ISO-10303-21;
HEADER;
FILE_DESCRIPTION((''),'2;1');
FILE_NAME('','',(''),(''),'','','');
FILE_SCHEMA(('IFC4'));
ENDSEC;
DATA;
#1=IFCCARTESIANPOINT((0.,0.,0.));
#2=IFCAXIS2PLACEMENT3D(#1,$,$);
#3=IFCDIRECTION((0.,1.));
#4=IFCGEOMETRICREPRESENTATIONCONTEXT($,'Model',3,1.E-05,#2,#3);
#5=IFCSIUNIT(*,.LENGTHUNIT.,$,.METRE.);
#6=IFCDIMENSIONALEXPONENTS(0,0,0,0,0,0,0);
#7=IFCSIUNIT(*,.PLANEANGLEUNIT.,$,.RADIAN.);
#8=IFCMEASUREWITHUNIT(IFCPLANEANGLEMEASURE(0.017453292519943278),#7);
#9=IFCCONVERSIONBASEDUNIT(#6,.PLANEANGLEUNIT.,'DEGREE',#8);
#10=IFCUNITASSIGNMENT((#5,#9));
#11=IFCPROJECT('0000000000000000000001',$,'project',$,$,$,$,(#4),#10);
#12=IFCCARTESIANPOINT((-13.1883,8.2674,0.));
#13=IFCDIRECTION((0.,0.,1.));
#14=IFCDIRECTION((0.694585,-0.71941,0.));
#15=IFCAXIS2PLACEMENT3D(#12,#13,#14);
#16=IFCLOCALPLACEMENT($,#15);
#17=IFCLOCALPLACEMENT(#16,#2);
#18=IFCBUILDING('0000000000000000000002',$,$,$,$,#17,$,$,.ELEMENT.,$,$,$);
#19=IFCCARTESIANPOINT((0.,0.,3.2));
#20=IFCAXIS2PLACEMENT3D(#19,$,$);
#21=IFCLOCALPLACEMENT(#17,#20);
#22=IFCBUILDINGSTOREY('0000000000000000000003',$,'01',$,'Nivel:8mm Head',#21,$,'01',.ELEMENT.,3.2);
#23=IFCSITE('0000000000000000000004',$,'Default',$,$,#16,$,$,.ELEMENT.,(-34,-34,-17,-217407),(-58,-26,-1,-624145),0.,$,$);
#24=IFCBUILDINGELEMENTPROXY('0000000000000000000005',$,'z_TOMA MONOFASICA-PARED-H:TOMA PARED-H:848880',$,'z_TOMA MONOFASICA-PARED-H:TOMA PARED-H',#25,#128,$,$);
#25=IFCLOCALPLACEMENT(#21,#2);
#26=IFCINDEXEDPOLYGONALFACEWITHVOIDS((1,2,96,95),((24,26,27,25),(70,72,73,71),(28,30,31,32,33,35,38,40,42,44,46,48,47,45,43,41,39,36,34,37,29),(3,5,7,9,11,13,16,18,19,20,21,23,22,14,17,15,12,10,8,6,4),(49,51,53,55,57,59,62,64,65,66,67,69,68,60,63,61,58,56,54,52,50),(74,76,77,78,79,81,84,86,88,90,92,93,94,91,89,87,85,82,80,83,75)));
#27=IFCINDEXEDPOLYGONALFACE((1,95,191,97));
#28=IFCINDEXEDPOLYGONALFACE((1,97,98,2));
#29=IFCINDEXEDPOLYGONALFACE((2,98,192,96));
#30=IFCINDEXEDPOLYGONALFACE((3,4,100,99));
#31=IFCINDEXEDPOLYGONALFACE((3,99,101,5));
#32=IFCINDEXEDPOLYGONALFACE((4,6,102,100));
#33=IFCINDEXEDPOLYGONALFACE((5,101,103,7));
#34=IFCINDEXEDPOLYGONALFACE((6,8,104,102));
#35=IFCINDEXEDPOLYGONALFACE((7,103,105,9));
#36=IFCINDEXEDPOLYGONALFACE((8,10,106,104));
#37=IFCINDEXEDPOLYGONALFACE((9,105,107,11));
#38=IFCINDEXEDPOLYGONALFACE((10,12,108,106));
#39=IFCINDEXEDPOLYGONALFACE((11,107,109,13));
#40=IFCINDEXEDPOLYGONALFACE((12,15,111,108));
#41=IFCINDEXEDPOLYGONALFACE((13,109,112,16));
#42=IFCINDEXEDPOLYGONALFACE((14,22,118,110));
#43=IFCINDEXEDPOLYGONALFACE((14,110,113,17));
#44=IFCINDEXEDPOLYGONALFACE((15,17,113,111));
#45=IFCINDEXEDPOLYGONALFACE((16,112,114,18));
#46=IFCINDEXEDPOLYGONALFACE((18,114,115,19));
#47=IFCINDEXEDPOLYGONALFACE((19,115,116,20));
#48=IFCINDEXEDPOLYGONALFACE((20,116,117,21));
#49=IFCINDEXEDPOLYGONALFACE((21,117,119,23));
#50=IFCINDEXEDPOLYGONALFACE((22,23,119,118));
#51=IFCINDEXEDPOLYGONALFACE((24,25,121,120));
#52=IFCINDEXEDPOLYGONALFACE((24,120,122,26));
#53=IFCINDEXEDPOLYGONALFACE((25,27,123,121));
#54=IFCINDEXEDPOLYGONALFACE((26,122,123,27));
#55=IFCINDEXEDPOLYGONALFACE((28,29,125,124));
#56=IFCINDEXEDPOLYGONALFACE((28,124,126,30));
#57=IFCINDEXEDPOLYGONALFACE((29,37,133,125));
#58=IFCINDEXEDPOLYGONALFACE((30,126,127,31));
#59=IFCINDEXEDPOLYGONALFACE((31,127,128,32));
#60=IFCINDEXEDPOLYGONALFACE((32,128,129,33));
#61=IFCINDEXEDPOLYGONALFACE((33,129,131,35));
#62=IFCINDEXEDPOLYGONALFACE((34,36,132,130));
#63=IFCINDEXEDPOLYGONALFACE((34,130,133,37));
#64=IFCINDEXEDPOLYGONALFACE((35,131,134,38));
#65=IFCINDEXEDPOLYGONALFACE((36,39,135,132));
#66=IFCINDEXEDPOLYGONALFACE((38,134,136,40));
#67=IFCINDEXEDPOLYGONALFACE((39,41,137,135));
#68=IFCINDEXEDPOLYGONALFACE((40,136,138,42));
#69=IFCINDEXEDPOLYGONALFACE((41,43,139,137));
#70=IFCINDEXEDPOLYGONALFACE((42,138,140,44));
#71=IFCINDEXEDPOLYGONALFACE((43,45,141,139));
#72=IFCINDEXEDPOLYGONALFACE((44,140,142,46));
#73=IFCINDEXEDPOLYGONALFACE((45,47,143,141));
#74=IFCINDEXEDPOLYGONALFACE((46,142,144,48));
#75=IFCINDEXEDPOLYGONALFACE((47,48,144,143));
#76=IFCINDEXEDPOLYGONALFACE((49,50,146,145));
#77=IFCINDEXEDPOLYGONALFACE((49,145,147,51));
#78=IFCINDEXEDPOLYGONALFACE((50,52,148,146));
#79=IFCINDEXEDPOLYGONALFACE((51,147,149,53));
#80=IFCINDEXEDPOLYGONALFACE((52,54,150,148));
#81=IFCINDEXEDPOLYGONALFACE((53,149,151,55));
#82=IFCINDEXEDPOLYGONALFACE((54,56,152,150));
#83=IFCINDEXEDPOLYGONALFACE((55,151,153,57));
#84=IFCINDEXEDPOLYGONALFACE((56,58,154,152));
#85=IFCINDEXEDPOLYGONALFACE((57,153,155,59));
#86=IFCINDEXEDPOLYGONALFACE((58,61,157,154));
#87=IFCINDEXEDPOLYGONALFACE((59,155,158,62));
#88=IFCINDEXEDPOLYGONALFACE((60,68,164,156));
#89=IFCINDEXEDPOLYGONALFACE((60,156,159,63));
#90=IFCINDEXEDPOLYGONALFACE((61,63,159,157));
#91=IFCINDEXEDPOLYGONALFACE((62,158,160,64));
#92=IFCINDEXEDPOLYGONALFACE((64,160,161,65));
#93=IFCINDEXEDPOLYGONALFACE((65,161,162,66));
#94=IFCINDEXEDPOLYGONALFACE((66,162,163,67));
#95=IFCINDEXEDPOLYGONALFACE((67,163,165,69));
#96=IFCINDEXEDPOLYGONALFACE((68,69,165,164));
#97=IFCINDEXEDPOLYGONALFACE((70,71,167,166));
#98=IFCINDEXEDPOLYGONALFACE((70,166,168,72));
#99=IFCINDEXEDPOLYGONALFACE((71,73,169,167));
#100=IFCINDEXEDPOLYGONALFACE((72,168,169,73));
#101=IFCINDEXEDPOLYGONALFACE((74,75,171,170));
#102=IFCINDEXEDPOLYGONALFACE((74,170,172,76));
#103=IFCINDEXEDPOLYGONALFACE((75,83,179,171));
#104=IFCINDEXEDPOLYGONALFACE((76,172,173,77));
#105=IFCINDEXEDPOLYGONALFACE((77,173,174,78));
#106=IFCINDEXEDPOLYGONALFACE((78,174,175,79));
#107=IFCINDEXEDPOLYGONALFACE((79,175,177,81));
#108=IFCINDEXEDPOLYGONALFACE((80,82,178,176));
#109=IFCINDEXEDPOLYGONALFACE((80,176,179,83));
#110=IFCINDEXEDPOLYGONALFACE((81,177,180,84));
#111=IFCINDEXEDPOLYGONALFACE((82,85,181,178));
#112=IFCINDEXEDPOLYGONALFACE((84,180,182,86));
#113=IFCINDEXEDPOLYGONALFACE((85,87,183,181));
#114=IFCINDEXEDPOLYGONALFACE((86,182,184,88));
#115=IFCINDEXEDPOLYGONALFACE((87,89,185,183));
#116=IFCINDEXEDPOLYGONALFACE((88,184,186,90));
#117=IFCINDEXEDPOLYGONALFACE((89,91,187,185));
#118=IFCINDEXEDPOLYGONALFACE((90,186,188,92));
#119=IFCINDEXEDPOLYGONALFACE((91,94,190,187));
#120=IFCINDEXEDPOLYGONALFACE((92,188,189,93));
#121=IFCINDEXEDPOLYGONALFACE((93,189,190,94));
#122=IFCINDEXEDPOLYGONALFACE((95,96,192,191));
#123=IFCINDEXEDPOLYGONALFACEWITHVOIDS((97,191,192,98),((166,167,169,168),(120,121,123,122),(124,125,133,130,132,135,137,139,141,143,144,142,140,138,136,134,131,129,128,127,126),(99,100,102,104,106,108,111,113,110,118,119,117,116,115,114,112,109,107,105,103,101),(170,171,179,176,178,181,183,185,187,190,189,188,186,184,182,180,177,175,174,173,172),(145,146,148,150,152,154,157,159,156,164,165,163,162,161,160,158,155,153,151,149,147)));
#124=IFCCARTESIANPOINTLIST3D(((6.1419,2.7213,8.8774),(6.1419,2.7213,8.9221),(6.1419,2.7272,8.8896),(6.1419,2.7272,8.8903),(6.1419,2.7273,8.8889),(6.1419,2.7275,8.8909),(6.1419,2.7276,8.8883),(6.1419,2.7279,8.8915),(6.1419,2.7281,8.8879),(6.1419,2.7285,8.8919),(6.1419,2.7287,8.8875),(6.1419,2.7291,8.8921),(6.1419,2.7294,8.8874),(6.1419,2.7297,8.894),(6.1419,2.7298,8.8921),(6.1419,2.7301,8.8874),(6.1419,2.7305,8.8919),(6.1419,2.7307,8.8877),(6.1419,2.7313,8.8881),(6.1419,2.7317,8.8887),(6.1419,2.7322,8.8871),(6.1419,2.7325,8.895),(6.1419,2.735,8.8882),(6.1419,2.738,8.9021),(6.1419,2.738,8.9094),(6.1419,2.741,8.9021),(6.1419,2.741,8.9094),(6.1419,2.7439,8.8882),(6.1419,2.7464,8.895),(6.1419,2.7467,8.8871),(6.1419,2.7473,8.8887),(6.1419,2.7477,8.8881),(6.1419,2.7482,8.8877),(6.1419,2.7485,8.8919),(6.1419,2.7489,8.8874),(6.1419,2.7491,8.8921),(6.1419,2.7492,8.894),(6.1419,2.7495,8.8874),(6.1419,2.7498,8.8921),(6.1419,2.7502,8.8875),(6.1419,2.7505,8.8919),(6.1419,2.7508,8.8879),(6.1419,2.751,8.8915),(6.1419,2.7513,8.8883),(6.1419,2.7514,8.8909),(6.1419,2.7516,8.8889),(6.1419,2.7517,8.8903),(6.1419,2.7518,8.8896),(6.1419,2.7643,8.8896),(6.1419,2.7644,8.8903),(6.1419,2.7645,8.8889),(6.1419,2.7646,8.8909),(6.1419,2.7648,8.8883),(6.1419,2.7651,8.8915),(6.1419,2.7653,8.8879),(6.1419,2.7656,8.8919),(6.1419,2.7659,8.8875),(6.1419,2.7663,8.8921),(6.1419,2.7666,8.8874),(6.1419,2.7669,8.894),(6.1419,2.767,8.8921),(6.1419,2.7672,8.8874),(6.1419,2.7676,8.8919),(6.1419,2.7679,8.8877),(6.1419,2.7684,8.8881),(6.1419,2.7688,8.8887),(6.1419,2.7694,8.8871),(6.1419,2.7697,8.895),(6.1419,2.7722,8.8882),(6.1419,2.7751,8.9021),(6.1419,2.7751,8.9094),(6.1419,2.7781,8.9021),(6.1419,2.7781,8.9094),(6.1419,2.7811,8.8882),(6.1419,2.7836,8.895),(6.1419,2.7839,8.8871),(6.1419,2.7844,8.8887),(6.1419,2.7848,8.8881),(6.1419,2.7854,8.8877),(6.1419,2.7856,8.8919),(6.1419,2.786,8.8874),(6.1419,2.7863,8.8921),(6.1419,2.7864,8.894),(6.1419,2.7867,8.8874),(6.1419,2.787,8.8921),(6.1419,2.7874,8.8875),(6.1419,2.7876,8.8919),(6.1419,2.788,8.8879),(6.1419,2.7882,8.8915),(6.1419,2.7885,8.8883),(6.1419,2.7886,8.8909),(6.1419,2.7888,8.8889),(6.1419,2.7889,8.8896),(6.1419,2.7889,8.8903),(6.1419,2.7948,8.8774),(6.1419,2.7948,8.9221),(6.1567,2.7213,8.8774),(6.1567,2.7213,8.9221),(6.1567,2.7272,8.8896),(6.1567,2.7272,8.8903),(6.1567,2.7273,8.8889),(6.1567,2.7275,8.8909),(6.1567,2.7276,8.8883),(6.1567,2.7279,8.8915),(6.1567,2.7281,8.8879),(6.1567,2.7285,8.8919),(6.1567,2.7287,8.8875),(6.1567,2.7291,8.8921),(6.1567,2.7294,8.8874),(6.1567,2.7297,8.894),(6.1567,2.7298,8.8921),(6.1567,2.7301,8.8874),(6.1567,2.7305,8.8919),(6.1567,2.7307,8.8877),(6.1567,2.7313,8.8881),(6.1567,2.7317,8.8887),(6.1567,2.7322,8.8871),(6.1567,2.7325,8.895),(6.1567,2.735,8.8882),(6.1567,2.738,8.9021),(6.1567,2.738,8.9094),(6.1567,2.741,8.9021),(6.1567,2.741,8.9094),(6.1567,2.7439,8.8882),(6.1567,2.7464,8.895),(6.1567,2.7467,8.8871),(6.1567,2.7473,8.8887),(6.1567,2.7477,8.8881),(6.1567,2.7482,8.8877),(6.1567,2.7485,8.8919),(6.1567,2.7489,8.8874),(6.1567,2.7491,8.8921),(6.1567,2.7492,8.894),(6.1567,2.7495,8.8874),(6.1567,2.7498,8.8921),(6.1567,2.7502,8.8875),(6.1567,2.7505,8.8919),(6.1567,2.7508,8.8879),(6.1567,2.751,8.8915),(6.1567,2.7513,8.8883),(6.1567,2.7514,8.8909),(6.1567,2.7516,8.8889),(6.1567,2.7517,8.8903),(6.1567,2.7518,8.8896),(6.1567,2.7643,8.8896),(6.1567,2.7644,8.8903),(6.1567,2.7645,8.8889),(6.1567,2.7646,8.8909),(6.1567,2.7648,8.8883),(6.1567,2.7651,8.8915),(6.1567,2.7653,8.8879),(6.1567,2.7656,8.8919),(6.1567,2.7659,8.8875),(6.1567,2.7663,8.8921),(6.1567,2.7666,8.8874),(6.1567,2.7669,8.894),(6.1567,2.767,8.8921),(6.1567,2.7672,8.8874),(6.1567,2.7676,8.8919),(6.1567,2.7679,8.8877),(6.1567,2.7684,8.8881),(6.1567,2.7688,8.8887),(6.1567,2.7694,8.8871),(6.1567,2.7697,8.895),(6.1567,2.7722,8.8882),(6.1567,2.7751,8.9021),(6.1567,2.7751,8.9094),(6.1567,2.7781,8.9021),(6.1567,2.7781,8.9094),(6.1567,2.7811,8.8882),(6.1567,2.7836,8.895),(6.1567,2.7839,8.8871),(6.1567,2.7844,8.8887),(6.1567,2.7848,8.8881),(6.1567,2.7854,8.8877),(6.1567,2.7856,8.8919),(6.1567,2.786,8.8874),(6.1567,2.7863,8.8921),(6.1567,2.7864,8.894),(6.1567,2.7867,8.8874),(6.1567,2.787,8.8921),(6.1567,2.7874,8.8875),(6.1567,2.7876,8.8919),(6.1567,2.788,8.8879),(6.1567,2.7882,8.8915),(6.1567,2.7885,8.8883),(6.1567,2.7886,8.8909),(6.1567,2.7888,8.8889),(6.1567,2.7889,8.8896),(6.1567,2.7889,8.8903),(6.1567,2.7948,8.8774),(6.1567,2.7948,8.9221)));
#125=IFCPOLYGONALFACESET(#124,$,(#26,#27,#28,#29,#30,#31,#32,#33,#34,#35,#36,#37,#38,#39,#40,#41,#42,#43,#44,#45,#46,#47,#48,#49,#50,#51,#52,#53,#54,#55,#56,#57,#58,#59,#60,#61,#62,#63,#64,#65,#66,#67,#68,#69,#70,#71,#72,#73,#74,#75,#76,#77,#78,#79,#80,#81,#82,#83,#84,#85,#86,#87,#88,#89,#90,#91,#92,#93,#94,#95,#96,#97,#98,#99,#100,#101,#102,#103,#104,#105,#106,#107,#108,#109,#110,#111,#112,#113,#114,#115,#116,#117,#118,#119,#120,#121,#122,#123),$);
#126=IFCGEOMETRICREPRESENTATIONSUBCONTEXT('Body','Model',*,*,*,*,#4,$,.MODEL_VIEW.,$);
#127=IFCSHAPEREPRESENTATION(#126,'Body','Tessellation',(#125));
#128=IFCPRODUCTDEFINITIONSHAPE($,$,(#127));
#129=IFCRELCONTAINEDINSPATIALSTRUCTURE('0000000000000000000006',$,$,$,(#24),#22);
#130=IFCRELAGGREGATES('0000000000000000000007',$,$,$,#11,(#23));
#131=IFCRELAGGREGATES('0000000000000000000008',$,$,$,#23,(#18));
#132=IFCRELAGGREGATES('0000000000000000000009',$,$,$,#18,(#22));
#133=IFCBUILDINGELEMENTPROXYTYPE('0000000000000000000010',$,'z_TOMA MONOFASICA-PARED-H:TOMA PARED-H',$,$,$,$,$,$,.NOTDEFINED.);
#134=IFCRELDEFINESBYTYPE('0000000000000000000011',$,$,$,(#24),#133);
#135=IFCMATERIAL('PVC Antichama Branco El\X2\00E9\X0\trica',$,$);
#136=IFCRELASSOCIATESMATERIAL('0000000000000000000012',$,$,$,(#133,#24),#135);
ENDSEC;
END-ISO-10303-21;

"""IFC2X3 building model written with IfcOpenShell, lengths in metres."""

from ifc_helpers import new_model, entity, si_unit, converted_unit, direction, frame, frame_2d, origin, place, context, subcontext, project, spatial, polyline, circle_curve, parameter, trimmed, segment, composite_curve, outline, extrude, source, transform, mapped, material, type_object, type_shapes, element, save


model = new_model("IFC2X3")

# Units and contexts
model_context = context("Model", 3, precision=1e-05, world=origin(), true_north=direction((0.0, 1.0)))
body_context = subcontext(model_context, "Body", "Model", "MODEL_VIEW")
ifc_project = project(units=[si_unit("LENGTHUNIT", "METRE"), converted_unit("PLANEANGLEUNIT", "DEGREE", entity("IfcPlaneAngleMeasure", 0.017453292519943278), si_unit("PLANEANGLEUNIT", "RADIAN"), dimensions=[0, 0, 0, 0, 0, 0, 0])], contexts=[model_context])

# Site, building, storey
site_placement = place(None, frame((-13.1883, 8.2674, 0.0), z_axis=(0.0, 0.0, 1.0), x_axis=(0.694585, -0.71941, 0.0)))
site = spatial("IfcSite", under=ifc_project, at=site_placement, Name="Default", CompositionType="ELEMENT", RefLatitude=(-34, -34, -17, -217407), RefLongitude=(-58, -26, -1, -624145), RefElevation=0.0)
building_placement = place(site_placement, origin())
building = spatial("IfcBuilding", under=site, at=building_placement, CompositionType="ELEMENT")
storey_placement = place(building_placement, frame((0.0, 0.0, 3.2)))
storey = spatial("IfcBuildingStorey", under=building, at=storey_placement, Name="01", ObjectType="Nivel:8mm Head", LongName="01", CompositionType="ELEMENT", Elevation=3.2)

# Building element proxy
ifc_material_1 = material(Name="PVC Antichama Branco Elétrica")
building_element_proxy_type_1 = type_object("IfcBuildingElementProxyType", Name="z_TOMA MONOFASICA-PARED-H:TOMA PARED-H", PredefinedType="NOTDEFINED", material=ifc_material_1)
shared_shape_1 = source(origin(), body_context, "Body", "SweptSolid", [
    extrude(outline(polyline([(-0.0368, -0.0223), (0.0368, -0.0223), (0.0368, 0.0223), (-0.0368, 0.0223), (-0.0368, -0.0223)]), holes=[composite_curve([segment(polyline([(0.0141, 0.0115), (0.0116, 0.0047)]), True, "CONTINUOUS"), segment(polyline([(0.0116, 0.0047), (0.0088, 0.0057)]), True, "CONTINUOUS"), segment(polyline([(0.0088, 0.0057), (0.0096, 0.0078)]), True, "CONTINUOUS"), segment(trimmed(circle_curve(frame_2d((0.0087, 0.0099), x_axis=(1.0, 0.0)), 0.0024), [parameter(27.118901)], [parameter(292.881099)], True, "PARAMETER"), False, "CONTINUOUS"), segment(polyline([(0.0108, 0.011), (0.0113, 0.0126)]), True, "CONTINUOUS"), segment(polyline([(0.0113, 0.0126), (0.0141, 0.0115)]), True, "CONTINUOUS")], self_intersect=False), composite_curve([segment(polyline([(0.0255, 0.0047), (0.023, 0.0115)]), True, "CONTINUOUS"), segment(polyline([(0.023, 0.0115), (0.0258, 0.0126)]), True, "CONTINUOUS"), segment(polyline([(0.0258, 0.0126), (0.0264, 0.011)]), True, "CONTINUOUS"), segment(trimmed(circle_curve(frame_2d((0.0285, 0.0099), x_axis=(1.0, 0.0)), 0.0024), [parameter(247.118901)], [parameter(152.881099)], True, "PARAMETER"), False, "CONTINUOUS"), segment(polyline([(0.0276, 0.0078), (0.0283, 0.0057)]), True, "CONTINUOUS"), segment(polyline([(0.0283, 0.0057), (0.0255, 0.0047)]), True, "CONTINUOUS")], self_intersect=False), polyline([(0.0201, -0.0024), (0.0201, -0.0097), (0.0171, -0.0097), (0.0171, -0.0024), (0.0201, -0.0024)]), composite_curve([segment(polyline([(-0.0141, 0.0115), (-0.0113, 0.0126)]), True, "CONTINUOUS"), segment(polyline([(-0.0113, 0.0126), (-0.0108, 0.011)]), True, "CONTINUOUS"), segment(trimmed(circle_curve(frame_2d((-0.0087, 0.0099), x_axis=(1.0, 0.0)), 0.0024), [parameter(247.118901)], [parameter(152.881099)], True, "PARAMETER"), False, "CONTINUOUS"), segment(polyline([(-0.0096, 0.0078), (-0.0088, 0.0057)]), True, "CONTINUOUS"), segment(polyline([(-0.0088, 0.0057), (-0.0116, 0.0047)]), True, "CONTINUOUS"), segment(polyline([(-0.0116, 0.0047), (-0.0141, 0.0115)]), True, "CONTINUOUS")], self_intersect=False), composite_curve([segment(polyline([(-0.0255, 0.0047), (-0.0283, 0.0057)]), True, "CONTINUOUS"), segment(polyline([(-0.0283, 0.0057), (-0.0276, 0.0078)]), True, "CONTINUOUS"), segment(trimmed(circle_curve(frame_2d((-0.0285, 0.0099), x_axis=(1.0, 0.0)), 0.0024), [parameter(27.118901)], [parameter(292.881099)], True, "PARAMETER"), False, "CONTINUOUS"), segment(polyline([(-0.0264, 0.011), (-0.0258, 0.0126)]), True, "CONTINUOUS"), segment(polyline([(-0.0258, 0.0126), (-0.023, 0.0115)]), True, "CONTINUOUS"), segment(polyline([(-0.023, 0.0115), (-0.0255, 0.0047)]), True, "CONTINUOUS")], self_intersect=False), polyline([(-0.0201, -0.0024), (-0.0171, -0.0024), (-0.0171, -0.0097), (-0.0201, -0.0097), (-0.0201, -0.0024)])]), frame((0.0, -0.005, 0.0223), z_axis=(0.0, 1.0, 0.0), x_axis=(1.0, 0.0, 0.0)), (0.0, 0.0, 1.0), 0.0148),
])
type_shapes(building_element_proxy_type_1, [shared_shape_1])
for number, where, z_axis, x_axis, name in (
    (1, (6.1469, 2.758, 8.8774), (0.0, 0.0, 1.0), (0.0, -1.0, 0.0), "z_TOMA MONOFASICA-PARED-H:TOMA PARED-H:848880"),
):
    element("IfcBuildingElementProxy", number, at=place(storey_placement, frame(where, z_axis=z_axis, x_axis=x_axis)), inside=storey, type_object=building_element_proxy_type_1, material=ifc_material_1, Name=name, ObjectType="z_TOMA MONOFASICA-PARED-H:TOMA PARED-H", context=body_context, shape_type="MappedRepresentation", body=[
        mapped(shared_shape_1, transform((0.0, 0.0, 0.0), scale=1.0)),
    ])

save(model, "model.ifc")
